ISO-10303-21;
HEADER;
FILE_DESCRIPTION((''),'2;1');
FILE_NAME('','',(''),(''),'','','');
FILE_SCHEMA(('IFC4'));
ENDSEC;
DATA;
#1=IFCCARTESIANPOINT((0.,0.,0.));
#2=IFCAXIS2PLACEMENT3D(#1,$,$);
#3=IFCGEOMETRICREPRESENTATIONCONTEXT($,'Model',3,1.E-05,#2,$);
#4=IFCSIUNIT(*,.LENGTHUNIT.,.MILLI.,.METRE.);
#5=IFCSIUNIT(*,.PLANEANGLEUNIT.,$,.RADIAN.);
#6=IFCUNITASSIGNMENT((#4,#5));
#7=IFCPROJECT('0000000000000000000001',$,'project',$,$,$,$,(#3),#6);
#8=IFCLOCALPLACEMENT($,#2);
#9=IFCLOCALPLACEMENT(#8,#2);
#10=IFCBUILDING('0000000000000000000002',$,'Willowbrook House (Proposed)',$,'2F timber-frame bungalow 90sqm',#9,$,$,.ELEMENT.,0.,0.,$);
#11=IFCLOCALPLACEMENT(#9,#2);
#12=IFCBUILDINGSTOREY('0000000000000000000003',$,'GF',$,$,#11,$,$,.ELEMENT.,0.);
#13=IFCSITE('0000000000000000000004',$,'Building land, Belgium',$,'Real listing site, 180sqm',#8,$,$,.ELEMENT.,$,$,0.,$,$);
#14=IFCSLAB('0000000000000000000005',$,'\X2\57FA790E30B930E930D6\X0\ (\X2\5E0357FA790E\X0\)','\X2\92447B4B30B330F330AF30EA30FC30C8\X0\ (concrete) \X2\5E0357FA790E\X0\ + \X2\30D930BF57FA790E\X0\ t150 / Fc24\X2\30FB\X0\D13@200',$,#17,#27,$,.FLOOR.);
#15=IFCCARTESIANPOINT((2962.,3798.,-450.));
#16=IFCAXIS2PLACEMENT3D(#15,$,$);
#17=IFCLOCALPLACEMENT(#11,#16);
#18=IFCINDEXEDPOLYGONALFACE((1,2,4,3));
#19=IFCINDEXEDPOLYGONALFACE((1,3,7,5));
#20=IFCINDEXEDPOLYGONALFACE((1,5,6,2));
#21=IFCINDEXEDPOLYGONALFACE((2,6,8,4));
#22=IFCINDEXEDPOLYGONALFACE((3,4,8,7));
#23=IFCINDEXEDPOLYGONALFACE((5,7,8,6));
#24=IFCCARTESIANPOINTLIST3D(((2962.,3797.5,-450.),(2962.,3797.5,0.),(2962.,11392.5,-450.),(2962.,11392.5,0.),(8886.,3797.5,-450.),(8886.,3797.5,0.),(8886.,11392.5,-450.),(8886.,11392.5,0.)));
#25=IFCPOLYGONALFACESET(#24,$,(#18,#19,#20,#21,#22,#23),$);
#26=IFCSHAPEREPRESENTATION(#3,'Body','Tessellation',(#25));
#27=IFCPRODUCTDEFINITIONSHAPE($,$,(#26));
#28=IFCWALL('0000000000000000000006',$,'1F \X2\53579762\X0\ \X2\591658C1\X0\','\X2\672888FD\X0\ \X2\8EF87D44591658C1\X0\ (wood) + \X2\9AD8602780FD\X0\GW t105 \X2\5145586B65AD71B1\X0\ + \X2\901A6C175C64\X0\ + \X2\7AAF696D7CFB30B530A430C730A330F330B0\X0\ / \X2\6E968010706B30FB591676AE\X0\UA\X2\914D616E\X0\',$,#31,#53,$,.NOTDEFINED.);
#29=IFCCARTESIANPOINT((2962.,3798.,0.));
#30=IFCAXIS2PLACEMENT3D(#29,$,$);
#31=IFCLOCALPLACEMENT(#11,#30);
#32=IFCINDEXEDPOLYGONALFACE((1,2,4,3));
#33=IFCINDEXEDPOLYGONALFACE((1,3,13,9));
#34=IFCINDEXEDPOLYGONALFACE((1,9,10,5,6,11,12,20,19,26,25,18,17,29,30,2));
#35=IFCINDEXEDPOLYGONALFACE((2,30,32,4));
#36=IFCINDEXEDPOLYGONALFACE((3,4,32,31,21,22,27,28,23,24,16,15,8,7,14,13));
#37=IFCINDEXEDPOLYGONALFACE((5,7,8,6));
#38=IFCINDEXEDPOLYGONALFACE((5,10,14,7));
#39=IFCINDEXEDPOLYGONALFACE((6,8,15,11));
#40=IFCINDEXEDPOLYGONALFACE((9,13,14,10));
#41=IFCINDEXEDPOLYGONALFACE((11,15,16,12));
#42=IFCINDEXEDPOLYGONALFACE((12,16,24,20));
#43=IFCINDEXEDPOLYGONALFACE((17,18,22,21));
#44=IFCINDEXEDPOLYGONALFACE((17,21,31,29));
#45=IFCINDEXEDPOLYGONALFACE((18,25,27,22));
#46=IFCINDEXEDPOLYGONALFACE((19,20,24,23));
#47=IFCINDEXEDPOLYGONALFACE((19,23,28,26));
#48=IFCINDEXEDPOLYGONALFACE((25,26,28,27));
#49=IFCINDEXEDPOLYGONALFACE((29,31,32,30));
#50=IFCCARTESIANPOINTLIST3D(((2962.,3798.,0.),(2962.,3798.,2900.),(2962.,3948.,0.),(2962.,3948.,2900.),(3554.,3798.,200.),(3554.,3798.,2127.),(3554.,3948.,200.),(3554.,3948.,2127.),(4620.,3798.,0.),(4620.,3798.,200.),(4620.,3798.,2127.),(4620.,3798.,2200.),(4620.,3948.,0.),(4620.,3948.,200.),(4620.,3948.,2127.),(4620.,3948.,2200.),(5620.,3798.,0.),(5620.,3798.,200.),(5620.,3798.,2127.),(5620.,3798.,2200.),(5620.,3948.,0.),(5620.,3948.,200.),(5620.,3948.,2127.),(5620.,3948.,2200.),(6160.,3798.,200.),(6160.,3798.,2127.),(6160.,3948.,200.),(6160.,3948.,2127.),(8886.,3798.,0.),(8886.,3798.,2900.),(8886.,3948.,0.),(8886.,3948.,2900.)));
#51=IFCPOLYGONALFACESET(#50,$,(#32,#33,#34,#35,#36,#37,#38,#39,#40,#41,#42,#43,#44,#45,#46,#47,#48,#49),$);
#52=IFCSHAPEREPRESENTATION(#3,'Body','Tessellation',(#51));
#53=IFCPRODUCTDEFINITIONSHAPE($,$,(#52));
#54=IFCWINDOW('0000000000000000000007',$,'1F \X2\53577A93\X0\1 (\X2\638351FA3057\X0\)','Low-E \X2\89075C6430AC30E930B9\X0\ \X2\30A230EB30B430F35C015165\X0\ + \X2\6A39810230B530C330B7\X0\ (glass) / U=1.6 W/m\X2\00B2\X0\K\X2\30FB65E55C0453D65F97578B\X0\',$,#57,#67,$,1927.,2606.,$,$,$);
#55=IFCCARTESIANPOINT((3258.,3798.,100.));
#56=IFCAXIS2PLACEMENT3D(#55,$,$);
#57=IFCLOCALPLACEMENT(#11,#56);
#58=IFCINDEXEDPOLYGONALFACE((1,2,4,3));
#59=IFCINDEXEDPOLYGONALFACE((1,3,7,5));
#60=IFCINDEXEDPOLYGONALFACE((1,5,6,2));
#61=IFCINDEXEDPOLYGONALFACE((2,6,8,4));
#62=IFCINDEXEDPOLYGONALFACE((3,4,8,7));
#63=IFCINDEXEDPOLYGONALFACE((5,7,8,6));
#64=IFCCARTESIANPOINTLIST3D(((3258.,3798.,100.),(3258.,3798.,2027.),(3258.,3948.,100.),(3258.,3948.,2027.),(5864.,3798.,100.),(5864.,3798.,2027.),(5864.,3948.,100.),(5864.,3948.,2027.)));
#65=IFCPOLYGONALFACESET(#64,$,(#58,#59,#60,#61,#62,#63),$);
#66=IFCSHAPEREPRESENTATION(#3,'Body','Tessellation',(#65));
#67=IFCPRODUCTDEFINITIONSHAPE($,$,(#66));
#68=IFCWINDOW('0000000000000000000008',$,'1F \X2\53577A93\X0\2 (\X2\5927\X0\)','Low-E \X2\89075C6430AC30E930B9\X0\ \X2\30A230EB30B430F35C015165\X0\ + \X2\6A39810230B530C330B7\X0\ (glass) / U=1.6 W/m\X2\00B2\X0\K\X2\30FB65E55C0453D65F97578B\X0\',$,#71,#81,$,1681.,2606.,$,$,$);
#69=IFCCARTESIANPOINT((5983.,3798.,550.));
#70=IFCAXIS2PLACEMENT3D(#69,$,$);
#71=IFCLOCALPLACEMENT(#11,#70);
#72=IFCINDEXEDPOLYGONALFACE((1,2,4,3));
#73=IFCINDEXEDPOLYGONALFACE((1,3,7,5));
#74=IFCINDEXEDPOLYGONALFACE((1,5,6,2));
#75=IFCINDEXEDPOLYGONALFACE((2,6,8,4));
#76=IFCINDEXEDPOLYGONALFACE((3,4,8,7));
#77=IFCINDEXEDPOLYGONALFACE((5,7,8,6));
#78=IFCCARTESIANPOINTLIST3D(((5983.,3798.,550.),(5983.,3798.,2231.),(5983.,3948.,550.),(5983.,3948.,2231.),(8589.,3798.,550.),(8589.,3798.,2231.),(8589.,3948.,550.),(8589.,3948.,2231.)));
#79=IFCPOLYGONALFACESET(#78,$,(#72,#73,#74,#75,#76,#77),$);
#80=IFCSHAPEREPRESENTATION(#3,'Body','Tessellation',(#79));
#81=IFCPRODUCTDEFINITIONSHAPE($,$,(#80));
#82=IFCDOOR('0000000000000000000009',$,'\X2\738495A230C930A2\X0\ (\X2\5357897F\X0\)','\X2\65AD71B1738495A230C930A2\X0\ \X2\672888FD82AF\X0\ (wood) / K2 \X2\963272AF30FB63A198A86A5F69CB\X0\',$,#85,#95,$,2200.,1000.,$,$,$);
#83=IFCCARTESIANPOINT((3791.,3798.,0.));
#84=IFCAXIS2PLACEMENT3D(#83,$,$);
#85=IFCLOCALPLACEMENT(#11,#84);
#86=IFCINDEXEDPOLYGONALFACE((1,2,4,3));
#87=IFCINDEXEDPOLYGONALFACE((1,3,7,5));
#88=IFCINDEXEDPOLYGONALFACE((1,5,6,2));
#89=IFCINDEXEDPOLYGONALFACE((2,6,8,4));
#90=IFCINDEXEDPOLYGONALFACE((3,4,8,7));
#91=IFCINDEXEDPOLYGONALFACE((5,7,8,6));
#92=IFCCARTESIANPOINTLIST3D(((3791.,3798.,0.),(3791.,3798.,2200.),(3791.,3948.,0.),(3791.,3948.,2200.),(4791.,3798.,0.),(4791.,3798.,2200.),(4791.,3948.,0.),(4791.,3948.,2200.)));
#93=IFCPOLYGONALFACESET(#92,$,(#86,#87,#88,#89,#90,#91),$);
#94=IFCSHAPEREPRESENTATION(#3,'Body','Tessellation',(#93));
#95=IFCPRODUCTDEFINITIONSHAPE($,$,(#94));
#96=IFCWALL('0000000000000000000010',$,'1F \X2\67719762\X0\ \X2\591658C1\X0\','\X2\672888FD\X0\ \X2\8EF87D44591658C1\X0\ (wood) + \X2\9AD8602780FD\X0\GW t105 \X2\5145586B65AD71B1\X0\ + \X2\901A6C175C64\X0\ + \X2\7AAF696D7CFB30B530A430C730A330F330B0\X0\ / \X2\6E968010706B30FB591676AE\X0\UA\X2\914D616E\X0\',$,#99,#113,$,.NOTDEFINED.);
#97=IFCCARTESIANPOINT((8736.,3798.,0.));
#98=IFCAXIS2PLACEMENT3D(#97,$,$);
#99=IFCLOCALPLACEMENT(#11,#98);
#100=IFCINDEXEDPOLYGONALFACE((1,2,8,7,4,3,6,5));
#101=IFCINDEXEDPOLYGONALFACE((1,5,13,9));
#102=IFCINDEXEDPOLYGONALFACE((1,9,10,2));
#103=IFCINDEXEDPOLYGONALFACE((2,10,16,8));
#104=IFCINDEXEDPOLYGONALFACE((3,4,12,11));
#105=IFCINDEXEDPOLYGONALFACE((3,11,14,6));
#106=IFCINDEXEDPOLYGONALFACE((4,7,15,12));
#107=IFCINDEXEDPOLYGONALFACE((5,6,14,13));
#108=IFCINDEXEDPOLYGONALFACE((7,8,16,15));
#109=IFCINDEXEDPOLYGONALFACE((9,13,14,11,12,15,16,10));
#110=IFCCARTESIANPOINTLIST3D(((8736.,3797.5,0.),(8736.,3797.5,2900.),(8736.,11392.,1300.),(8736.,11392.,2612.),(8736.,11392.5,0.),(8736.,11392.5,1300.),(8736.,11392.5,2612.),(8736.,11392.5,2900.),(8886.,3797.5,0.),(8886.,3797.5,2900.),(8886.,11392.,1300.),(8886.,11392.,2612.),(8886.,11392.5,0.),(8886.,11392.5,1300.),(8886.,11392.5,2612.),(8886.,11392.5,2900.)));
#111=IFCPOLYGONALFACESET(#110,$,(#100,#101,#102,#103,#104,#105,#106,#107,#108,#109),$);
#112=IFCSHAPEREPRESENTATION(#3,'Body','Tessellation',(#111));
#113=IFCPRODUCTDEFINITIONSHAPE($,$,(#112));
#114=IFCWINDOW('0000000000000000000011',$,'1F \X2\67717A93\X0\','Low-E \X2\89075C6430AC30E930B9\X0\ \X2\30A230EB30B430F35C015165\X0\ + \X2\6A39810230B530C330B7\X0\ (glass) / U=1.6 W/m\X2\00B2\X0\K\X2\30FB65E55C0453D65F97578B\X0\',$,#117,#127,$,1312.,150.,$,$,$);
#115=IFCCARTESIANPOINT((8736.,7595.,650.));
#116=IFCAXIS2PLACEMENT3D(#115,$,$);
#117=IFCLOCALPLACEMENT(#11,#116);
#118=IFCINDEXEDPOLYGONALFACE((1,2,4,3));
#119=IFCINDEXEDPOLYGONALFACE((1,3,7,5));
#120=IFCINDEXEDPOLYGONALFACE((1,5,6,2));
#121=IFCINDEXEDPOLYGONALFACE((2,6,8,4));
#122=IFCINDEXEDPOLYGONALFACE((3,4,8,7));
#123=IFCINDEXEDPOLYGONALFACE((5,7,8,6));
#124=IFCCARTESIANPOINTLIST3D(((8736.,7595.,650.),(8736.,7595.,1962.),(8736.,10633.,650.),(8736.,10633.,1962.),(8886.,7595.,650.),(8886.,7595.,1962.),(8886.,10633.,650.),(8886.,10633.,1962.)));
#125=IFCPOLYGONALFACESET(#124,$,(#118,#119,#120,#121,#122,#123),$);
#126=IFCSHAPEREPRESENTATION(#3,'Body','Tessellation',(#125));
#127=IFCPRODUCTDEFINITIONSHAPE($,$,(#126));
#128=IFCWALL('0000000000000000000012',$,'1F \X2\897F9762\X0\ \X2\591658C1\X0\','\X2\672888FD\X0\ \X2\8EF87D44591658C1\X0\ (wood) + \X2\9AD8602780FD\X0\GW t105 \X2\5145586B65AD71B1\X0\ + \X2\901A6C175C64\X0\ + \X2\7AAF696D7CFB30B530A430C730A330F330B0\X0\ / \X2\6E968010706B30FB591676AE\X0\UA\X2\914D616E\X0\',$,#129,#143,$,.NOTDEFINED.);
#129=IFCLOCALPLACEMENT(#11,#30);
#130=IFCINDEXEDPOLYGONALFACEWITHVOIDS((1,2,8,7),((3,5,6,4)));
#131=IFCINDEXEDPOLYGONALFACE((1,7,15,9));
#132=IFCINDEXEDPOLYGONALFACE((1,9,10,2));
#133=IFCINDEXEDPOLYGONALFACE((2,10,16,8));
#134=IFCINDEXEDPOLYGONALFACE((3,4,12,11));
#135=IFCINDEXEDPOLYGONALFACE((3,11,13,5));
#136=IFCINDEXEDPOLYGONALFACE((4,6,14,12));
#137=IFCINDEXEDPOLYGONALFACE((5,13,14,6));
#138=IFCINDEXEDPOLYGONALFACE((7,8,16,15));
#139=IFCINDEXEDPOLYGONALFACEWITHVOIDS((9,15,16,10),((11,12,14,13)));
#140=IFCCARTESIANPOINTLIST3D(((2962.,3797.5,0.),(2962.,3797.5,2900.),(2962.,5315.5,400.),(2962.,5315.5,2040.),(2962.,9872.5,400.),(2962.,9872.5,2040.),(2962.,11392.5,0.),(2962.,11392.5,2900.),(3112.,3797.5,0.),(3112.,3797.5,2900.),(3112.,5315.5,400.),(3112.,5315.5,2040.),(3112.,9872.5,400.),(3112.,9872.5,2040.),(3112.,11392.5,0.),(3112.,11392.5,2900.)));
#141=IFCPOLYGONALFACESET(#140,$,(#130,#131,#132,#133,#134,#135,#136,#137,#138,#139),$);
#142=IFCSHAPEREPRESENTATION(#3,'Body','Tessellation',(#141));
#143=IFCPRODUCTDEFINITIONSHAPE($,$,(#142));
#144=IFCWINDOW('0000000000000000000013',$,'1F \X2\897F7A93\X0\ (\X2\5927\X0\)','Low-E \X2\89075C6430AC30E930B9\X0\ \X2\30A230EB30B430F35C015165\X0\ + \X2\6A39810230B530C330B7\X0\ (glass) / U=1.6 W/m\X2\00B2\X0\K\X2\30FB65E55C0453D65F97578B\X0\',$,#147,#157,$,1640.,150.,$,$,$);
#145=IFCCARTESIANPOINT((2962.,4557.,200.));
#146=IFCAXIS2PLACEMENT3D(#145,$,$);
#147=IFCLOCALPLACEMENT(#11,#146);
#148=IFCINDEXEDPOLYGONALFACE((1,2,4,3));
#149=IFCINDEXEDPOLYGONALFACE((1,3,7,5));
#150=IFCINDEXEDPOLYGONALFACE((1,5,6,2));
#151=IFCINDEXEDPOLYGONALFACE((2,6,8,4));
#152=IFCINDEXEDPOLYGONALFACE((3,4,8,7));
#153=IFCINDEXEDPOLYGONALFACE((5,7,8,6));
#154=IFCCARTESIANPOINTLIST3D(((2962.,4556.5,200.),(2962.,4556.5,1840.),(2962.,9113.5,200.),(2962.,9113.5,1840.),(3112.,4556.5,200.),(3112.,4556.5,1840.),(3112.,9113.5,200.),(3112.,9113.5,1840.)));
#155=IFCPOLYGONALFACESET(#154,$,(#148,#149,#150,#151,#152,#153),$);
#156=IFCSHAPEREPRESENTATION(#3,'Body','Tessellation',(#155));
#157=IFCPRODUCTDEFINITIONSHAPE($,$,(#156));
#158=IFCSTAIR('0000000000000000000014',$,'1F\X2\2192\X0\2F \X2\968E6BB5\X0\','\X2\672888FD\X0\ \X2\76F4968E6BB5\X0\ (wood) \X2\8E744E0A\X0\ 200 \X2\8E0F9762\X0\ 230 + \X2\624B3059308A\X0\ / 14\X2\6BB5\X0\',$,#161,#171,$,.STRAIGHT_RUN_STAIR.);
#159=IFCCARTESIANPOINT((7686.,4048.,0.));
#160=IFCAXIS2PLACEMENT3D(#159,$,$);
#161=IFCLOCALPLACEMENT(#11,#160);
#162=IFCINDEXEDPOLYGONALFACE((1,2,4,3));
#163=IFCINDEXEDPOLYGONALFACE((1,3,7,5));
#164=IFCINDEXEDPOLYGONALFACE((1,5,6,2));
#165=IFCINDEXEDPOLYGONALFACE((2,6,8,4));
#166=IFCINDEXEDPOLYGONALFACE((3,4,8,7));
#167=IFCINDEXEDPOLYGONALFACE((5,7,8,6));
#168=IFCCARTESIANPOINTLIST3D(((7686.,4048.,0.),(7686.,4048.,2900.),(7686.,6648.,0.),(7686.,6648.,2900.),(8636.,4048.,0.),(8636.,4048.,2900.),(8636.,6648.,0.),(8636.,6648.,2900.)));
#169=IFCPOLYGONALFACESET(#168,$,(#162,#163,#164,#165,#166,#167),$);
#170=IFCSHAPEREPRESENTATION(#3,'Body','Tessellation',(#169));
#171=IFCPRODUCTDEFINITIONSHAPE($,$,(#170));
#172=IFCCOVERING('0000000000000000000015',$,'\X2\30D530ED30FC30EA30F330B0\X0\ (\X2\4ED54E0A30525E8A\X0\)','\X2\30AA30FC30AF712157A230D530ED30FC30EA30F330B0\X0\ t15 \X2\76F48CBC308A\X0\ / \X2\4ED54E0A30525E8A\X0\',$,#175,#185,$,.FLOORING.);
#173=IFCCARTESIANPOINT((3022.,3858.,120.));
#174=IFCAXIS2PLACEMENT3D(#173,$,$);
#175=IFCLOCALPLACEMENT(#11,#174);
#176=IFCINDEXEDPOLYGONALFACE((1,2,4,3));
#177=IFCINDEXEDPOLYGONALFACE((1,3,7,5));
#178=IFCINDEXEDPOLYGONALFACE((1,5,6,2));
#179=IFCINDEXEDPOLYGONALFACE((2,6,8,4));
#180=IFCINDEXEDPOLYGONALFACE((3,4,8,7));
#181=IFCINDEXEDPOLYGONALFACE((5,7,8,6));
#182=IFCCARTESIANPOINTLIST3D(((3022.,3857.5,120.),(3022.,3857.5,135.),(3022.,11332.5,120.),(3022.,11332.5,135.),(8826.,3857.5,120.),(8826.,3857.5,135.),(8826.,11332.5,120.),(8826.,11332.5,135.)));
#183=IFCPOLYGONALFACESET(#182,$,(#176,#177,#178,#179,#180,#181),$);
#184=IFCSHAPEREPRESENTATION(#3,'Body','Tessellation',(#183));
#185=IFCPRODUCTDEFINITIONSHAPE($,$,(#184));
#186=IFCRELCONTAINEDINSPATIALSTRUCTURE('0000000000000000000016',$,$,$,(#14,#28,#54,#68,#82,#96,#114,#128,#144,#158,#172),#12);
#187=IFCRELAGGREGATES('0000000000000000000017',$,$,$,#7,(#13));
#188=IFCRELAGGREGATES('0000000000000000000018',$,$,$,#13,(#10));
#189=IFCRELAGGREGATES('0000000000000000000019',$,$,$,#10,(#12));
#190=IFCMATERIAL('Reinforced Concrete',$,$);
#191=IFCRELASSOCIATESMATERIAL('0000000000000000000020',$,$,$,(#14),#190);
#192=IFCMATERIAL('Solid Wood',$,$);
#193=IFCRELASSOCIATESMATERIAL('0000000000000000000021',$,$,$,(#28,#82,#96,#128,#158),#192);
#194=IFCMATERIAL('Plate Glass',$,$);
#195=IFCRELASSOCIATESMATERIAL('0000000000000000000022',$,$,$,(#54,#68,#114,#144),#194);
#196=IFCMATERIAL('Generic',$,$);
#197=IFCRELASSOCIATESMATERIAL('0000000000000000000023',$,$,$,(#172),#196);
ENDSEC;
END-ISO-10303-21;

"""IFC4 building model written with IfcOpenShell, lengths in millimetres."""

from ifc_helpers import new_model, si_unit, frame, frame_2d, origin, place, context, project, spatial, rectangle, extrude, material, element, fill, save


model = new_model("IFC4")

# Units and contexts
model_context = context("Model", 3, precision=1e-05, world=origin())
ifc_project = project(units=[si_unit("LENGTHUNIT", "METRE", prefix="MILLI"), si_unit("PLANEANGLEUNIT", "RADIAN")], contexts=[model_context])

# Site, building, storey
site_placement = place(None, origin())
site = spatial("IfcSite", under=ifc_project, at=site_placement, Name="Building land, Belgium", ObjectType="Real listing site, 180sqm", CompositionType="ELEMENT", RefElevation=0.0)
building_placement = place(site_placement, origin())
building = spatial("IfcBuilding", under=site, at=building_placement, Name="Willowbrook House (Proposed)", ObjectType="2F timber-frame bungalow 90sqm", CompositionType="ELEMENT", ElevationOfRefHeight=0.0, ElevationOfTerrain=0.0)
storey_placement = place(building_placement, origin())
storey = spatial("IfcBuildingStorey", under=building, at=storey_placement, Name="GF", CompositionType="ELEMENT", Elevation=0.0)

# Slab
ifc_material_1 = material(Name="Reinforced Concrete")
slab_1_placement = place(storey_placement, frame((2962.0, 3798.0, -450.0)))
element("IfcSlab", 1, at=slab_1_placement, inside=storey, material=ifc_material_1, Name="基礎スラブ (布基礎)", Description="鉄筋コンクリート (concrete) 布基礎 + ベタ基礎 t150 / Fc24・D13@200", PredefinedType="FLOOR", context=model_context, shape_type="SweptSolid", body=[
    extrude(rectangle(XDim=5924.0, YDim=7595.0, at=frame_2d((2962.0, 3797.0))), frame((2962.0, 3798.0, -450.0)), (0.0, 0.0, 1.0), 450.0),
])
ifc_material_2 = material(Name="Solid Wood")

# Wall, openings, windows, door
wall_1_placement = place(storey_placement, frame((2962.0, 3798.0, 0.0)))
wall_1 = element("IfcWall", 2, at=wall_1_placement, inside=storey, material=ifc_material_2, Name="1F 南面 外壁", Description="木製 軸組外壁 (wood) + 高性能GW t105 充填断熱 + 通気層 + 窯業系サイディング / 準耐火・外皮UA配慮", PredefinedType="NOTDEFINED", context=model_context, shape_type="SweptSolid", body=[
    extrude(rectangle(XDim=5924.0, YDim=150.0, at=frame_2d((2962.0, 75.0))), frame((2962.0, 3798.0, 0.0)), (0.0, 0.0, 1.0), 2900.0),
])
opening_1_placement = place(storey_placement, frame((3258.0, 3798.0, 100.0)))
opening_1 = element("IfcOpeningElement", 3, at=opening_1_placement, cuts=wall_1, PredefinedType="NOTDEFINED", context=model_context, shape_type="SweptSolid", body=[
    extrude(rectangle(XDim=2606.0, YDim=150.0, at=frame_2d((1303.0, 75.0))), frame((3258.0, 3798.0, 100.0)), (0.0, 0.0, 1.0), 1927.0),
])
opening_2_placement = place(storey_placement, frame((5983.0, 3798.0, 550.0)))
opening_2 = element("IfcOpeningElement", 4, at=opening_2_placement, cuts=wall_1, PredefinedType="NOTDEFINED", context=model_context, shape_type="SweptSolid", body=[
    extrude(rectangle(XDim=2606.0, YDim=150.0, at=frame_2d((1303.0, 75.0))), frame((5983.0, 3798.0, 550.0)), (0.0, 0.0, 1.0), 1681.0),
])
opening_3_placement = place(storey_placement, frame((3791.0, 3798.0, 0.0)))
opening_3 = element("IfcOpeningElement", 5, at=opening_3_placement, cuts=wall_1, PredefinedType="NOTDEFINED", context=model_context, shape_type="SweptSolid", body=[
    extrude(rectangle(XDim=1000.0, YDim=150.0, at=frame_2d((500.0, 75.0))), frame((3791.0, 3798.0, 0.0)), (0.0, 0.0, 1.0), 2200.0),
])
ifc_material_3 = material(Name="Plate Glass")
window_1_placement = place(storey_placement, frame((3258.0, 3798.0, 100.0)))
window_1 = element("IfcWindow", 6, at=window_1_placement, inside=storey, material=ifc_material_3, Name="1F 南窓1 (掃出し)", Description="Low-E 複層ガラス アルゴン封入 + 樹脂サッシ (glass) / U=1.6 W/m²K・日射取得型", OverallHeight=1927.0, OverallWidth=2606.0, context=model_context, shape_type="SweptSolid", body=[
    extrude(rectangle(XDim=2606.0, YDim=150.0, at=frame_2d((1303.0, 75.0))), frame((3258.0, 3798.0, 100.0)), (0.0, 0.0, 1.0), 1927.0),
])
fill(opening_1, window_1)
window_2_placement = place(storey_placement, frame((5983.0, 3798.0, 550.0)))
window_2 = element("IfcWindow", 7, at=window_2_placement, inside=storey, material=ifc_material_3, Name="1F 南窓2 (大)", Description="Low-E 複層ガラス アルゴン封入 + 樹脂サッシ (glass) / U=1.6 W/m²K・日射取得型", OverallHeight=1681.0, OverallWidth=2606.0, context=model_context, shape_type="SweptSolid", body=[
    extrude(rectangle(XDim=2606.0, YDim=150.0, at=frame_2d((1303.0, 75.0))), frame((5983.0, 3798.0, 550.0)), (0.0, 0.0, 1.0), 1681.0),
])
fill(opening_2, window_2)
door_placement = place(storey_placement, frame((3791.0, 3798.0, 0.0)))
door = element("IfcDoor", 8, at=door_placement, inside=storey, material=ifc_material_2, Name="玄関ドア (南西)", Description="断熱玄関ドア 木製芯 (wood) / K2 防犯・採風機構", OverallHeight=2200.0, OverallWidth=1000.0, context=model_context, shape_type="SweptSolid", body=[
    extrude(rectangle(XDim=1000.0, YDim=150.0, at=frame_2d((500.0, 75.0))), frame((3791.0, 3798.0, 0.0)), (0.0, 0.0, 1.0), 2200.0),
])
fill(opening_3, door)

# Walls, openings, windows
wall_2_placement = place(storey_placement, frame((8736.0, 3798.0, 0.0)))
wall_2 = element("IfcWall", 9, at=wall_2_placement, inside=storey, material=ifc_material_2, Name="1F 東面 外壁", Description="木製 軸組外壁 (wood) + 高性能GW t105 充填断熱 + 通気層 + 窯業系サイディング / 準耐火・外皮UA配慮", PredefinedType="NOTDEFINED", context=model_context, shape_type="SweptSolid", body=[
    extrude(rectangle(XDim=150.0, YDim=7595.0, at=frame_2d((75.0, 3797.0))), frame((8736.0, 3798.0, 0.0)), (0.0, 0.0, 1.0), 2900.0),
])
opening_4_placement = place(storey_placement, frame((8736.0, 7595.0, 650.0)))
opening_4 = element("IfcOpeningElement", 10, at=opening_4_placement, cuts=wall_2, PredefinedType="NOTDEFINED", context=model_context, shape_type="SweptSolid", body=[
    extrude(rectangle(XDim=150.0, YDim=3038.0, at=frame_2d((75.0, 1519.0))), frame((8736.0, 7595.0, 650.0)), (0.0, 0.0, 1.0), 1312.0),
])
window_3_placement = place(storey_placement, frame((8736.0, 7595.0, 650.0)))
window_3 = element("IfcWindow", 11, at=window_3_placement, inside=storey, material=ifc_material_3, Name="1F 東窓", Description="Low-E 複層ガラス アルゴン封入 + 樹脂サッシ (glass) / U=1.6 W/m²K・日射取得型", OverallHeight=1312.0, OverallWidth=150.0, context=model_context, shape_type="SweptSolid", body=[
    extrude(rectangle(XDim=150.0, YDim=3038.0, at=frame_2d((75.0, 1519.0))), frame((8736.0, 7595.0, 650.0)), (0.0, 0.0, 1.0), 1312.0),
])
fill(opening_4, window_3)
wall_3_placement = place(storey_placement, frame((2962.0, 3798.0, 0.0)))
wall_3 = element("IfcWall", 12, at=wall_3_placement, inside=storey, material=ifc_material_2, Name="1F 西面 外壁", Description="木製 軸組外壁 (wood) + 高性能GW t105 充填断熱 + 通気層 + 窯業系サイディング / 準耐火・外皮UA配慮", PredefinedType="NOTDEFINED", context=model_context, shape_type="SweptSolid", body=[
    extrude(rectangle(XDim=150.0, YDim=7595.0, at=frame_2d((75.0, 3797.0))), frame((2962.0, 3798.0, 0.0)), (0.0, 0.0, 1.0), 2900.0),
])
opening_5_placement = place(storey_placement, frame((2962.0, 4557.0, 200.0)))
opening_5 = element("IfcOpeningElement", 13, at=opening_5_placement, cuts=wall_3, PredefinedType="NOTDEFINED", context=model_context, shape_type="SweptSolid", body=[
    extrude(rectangle(XDim=150.0, YDim=4557.0, at=frame_2d((75.0, 2278.0))), frame((2962.0, 4557.0, 200.0)), (0.0, 0.0, 1.0), 1640.0),
])
window_4_placement = place(storey_placement, frame((2962.0, 4557.0, 200.0)))
window_4 = element("IfcWindow", 14, at=window_4_placement, inside=storey, material=ifc_material_3, Name="1F 西窓 (大)", Description="Low-E 複層ガラス アルゴン封入 + 樹脂サッシ (glass) / U=1.6 W/m²K・日射取得型", OverallHeight=1640.0, OverallWidth=150.0, context=model_context, shape_type="SweptSolid", body=[
    extrude(rectangle(XDim=150.0, YDim=4557.0, at=frame_2d((75.0, 2278.0))), frame((2962.0, 4557.0, 200.0)), (0.0, 0.0, 1.0), 1640.0),
])
fill(opening_5, window_4)

# Stair
stair_placement = place(storey_placement, frame((7686.0, 4048.0, 0.0)))
element("IfcStair", 15, at=stair_placement, inside=storey, material=ifc_material_2, Name="1F→2F 階段", Description="木製 直階段 (wood) 蹴上 200 踏面 230 + 手すり / 14段", PredefinedType="STRAIGHT_RUN_STAIR", context=model_context, shape_type="SweptSolid", body=[
    extrude(rectangle(XDim=950.0, YDim=2600.0, at=frame_2d((475.0, 1300.0))), frame((7686.0, 4048.0, 0.0)), (0.0, 0.0, 1.0), 2900.0),
])

# Covering
ifc_material_4 = material(Name="Generic")
covering_placement = place(storey_placement, frame((3022.0, 3858.0, 120.0)))
element("IfcCovering", 16, at=covering_placement, inside=storey, material=ifc_material_4, Name="フローリング (仕上げ床)", Description="オーク無垢フローリング t15 直貼り / 仕上げ床", PredefinedType="FLOORING", context=model_context, shape_type="SweptSolid", body=[
    extrude(rectangle(XDim=5804.0, YDim=7475.0, at=frame_2d((2902.0, 3737.0))), frame((3022.0, 3858.0, 120.0)), (0.0, 0.0, 1.0), 15.0),
])

save(model, "model.ifc")
